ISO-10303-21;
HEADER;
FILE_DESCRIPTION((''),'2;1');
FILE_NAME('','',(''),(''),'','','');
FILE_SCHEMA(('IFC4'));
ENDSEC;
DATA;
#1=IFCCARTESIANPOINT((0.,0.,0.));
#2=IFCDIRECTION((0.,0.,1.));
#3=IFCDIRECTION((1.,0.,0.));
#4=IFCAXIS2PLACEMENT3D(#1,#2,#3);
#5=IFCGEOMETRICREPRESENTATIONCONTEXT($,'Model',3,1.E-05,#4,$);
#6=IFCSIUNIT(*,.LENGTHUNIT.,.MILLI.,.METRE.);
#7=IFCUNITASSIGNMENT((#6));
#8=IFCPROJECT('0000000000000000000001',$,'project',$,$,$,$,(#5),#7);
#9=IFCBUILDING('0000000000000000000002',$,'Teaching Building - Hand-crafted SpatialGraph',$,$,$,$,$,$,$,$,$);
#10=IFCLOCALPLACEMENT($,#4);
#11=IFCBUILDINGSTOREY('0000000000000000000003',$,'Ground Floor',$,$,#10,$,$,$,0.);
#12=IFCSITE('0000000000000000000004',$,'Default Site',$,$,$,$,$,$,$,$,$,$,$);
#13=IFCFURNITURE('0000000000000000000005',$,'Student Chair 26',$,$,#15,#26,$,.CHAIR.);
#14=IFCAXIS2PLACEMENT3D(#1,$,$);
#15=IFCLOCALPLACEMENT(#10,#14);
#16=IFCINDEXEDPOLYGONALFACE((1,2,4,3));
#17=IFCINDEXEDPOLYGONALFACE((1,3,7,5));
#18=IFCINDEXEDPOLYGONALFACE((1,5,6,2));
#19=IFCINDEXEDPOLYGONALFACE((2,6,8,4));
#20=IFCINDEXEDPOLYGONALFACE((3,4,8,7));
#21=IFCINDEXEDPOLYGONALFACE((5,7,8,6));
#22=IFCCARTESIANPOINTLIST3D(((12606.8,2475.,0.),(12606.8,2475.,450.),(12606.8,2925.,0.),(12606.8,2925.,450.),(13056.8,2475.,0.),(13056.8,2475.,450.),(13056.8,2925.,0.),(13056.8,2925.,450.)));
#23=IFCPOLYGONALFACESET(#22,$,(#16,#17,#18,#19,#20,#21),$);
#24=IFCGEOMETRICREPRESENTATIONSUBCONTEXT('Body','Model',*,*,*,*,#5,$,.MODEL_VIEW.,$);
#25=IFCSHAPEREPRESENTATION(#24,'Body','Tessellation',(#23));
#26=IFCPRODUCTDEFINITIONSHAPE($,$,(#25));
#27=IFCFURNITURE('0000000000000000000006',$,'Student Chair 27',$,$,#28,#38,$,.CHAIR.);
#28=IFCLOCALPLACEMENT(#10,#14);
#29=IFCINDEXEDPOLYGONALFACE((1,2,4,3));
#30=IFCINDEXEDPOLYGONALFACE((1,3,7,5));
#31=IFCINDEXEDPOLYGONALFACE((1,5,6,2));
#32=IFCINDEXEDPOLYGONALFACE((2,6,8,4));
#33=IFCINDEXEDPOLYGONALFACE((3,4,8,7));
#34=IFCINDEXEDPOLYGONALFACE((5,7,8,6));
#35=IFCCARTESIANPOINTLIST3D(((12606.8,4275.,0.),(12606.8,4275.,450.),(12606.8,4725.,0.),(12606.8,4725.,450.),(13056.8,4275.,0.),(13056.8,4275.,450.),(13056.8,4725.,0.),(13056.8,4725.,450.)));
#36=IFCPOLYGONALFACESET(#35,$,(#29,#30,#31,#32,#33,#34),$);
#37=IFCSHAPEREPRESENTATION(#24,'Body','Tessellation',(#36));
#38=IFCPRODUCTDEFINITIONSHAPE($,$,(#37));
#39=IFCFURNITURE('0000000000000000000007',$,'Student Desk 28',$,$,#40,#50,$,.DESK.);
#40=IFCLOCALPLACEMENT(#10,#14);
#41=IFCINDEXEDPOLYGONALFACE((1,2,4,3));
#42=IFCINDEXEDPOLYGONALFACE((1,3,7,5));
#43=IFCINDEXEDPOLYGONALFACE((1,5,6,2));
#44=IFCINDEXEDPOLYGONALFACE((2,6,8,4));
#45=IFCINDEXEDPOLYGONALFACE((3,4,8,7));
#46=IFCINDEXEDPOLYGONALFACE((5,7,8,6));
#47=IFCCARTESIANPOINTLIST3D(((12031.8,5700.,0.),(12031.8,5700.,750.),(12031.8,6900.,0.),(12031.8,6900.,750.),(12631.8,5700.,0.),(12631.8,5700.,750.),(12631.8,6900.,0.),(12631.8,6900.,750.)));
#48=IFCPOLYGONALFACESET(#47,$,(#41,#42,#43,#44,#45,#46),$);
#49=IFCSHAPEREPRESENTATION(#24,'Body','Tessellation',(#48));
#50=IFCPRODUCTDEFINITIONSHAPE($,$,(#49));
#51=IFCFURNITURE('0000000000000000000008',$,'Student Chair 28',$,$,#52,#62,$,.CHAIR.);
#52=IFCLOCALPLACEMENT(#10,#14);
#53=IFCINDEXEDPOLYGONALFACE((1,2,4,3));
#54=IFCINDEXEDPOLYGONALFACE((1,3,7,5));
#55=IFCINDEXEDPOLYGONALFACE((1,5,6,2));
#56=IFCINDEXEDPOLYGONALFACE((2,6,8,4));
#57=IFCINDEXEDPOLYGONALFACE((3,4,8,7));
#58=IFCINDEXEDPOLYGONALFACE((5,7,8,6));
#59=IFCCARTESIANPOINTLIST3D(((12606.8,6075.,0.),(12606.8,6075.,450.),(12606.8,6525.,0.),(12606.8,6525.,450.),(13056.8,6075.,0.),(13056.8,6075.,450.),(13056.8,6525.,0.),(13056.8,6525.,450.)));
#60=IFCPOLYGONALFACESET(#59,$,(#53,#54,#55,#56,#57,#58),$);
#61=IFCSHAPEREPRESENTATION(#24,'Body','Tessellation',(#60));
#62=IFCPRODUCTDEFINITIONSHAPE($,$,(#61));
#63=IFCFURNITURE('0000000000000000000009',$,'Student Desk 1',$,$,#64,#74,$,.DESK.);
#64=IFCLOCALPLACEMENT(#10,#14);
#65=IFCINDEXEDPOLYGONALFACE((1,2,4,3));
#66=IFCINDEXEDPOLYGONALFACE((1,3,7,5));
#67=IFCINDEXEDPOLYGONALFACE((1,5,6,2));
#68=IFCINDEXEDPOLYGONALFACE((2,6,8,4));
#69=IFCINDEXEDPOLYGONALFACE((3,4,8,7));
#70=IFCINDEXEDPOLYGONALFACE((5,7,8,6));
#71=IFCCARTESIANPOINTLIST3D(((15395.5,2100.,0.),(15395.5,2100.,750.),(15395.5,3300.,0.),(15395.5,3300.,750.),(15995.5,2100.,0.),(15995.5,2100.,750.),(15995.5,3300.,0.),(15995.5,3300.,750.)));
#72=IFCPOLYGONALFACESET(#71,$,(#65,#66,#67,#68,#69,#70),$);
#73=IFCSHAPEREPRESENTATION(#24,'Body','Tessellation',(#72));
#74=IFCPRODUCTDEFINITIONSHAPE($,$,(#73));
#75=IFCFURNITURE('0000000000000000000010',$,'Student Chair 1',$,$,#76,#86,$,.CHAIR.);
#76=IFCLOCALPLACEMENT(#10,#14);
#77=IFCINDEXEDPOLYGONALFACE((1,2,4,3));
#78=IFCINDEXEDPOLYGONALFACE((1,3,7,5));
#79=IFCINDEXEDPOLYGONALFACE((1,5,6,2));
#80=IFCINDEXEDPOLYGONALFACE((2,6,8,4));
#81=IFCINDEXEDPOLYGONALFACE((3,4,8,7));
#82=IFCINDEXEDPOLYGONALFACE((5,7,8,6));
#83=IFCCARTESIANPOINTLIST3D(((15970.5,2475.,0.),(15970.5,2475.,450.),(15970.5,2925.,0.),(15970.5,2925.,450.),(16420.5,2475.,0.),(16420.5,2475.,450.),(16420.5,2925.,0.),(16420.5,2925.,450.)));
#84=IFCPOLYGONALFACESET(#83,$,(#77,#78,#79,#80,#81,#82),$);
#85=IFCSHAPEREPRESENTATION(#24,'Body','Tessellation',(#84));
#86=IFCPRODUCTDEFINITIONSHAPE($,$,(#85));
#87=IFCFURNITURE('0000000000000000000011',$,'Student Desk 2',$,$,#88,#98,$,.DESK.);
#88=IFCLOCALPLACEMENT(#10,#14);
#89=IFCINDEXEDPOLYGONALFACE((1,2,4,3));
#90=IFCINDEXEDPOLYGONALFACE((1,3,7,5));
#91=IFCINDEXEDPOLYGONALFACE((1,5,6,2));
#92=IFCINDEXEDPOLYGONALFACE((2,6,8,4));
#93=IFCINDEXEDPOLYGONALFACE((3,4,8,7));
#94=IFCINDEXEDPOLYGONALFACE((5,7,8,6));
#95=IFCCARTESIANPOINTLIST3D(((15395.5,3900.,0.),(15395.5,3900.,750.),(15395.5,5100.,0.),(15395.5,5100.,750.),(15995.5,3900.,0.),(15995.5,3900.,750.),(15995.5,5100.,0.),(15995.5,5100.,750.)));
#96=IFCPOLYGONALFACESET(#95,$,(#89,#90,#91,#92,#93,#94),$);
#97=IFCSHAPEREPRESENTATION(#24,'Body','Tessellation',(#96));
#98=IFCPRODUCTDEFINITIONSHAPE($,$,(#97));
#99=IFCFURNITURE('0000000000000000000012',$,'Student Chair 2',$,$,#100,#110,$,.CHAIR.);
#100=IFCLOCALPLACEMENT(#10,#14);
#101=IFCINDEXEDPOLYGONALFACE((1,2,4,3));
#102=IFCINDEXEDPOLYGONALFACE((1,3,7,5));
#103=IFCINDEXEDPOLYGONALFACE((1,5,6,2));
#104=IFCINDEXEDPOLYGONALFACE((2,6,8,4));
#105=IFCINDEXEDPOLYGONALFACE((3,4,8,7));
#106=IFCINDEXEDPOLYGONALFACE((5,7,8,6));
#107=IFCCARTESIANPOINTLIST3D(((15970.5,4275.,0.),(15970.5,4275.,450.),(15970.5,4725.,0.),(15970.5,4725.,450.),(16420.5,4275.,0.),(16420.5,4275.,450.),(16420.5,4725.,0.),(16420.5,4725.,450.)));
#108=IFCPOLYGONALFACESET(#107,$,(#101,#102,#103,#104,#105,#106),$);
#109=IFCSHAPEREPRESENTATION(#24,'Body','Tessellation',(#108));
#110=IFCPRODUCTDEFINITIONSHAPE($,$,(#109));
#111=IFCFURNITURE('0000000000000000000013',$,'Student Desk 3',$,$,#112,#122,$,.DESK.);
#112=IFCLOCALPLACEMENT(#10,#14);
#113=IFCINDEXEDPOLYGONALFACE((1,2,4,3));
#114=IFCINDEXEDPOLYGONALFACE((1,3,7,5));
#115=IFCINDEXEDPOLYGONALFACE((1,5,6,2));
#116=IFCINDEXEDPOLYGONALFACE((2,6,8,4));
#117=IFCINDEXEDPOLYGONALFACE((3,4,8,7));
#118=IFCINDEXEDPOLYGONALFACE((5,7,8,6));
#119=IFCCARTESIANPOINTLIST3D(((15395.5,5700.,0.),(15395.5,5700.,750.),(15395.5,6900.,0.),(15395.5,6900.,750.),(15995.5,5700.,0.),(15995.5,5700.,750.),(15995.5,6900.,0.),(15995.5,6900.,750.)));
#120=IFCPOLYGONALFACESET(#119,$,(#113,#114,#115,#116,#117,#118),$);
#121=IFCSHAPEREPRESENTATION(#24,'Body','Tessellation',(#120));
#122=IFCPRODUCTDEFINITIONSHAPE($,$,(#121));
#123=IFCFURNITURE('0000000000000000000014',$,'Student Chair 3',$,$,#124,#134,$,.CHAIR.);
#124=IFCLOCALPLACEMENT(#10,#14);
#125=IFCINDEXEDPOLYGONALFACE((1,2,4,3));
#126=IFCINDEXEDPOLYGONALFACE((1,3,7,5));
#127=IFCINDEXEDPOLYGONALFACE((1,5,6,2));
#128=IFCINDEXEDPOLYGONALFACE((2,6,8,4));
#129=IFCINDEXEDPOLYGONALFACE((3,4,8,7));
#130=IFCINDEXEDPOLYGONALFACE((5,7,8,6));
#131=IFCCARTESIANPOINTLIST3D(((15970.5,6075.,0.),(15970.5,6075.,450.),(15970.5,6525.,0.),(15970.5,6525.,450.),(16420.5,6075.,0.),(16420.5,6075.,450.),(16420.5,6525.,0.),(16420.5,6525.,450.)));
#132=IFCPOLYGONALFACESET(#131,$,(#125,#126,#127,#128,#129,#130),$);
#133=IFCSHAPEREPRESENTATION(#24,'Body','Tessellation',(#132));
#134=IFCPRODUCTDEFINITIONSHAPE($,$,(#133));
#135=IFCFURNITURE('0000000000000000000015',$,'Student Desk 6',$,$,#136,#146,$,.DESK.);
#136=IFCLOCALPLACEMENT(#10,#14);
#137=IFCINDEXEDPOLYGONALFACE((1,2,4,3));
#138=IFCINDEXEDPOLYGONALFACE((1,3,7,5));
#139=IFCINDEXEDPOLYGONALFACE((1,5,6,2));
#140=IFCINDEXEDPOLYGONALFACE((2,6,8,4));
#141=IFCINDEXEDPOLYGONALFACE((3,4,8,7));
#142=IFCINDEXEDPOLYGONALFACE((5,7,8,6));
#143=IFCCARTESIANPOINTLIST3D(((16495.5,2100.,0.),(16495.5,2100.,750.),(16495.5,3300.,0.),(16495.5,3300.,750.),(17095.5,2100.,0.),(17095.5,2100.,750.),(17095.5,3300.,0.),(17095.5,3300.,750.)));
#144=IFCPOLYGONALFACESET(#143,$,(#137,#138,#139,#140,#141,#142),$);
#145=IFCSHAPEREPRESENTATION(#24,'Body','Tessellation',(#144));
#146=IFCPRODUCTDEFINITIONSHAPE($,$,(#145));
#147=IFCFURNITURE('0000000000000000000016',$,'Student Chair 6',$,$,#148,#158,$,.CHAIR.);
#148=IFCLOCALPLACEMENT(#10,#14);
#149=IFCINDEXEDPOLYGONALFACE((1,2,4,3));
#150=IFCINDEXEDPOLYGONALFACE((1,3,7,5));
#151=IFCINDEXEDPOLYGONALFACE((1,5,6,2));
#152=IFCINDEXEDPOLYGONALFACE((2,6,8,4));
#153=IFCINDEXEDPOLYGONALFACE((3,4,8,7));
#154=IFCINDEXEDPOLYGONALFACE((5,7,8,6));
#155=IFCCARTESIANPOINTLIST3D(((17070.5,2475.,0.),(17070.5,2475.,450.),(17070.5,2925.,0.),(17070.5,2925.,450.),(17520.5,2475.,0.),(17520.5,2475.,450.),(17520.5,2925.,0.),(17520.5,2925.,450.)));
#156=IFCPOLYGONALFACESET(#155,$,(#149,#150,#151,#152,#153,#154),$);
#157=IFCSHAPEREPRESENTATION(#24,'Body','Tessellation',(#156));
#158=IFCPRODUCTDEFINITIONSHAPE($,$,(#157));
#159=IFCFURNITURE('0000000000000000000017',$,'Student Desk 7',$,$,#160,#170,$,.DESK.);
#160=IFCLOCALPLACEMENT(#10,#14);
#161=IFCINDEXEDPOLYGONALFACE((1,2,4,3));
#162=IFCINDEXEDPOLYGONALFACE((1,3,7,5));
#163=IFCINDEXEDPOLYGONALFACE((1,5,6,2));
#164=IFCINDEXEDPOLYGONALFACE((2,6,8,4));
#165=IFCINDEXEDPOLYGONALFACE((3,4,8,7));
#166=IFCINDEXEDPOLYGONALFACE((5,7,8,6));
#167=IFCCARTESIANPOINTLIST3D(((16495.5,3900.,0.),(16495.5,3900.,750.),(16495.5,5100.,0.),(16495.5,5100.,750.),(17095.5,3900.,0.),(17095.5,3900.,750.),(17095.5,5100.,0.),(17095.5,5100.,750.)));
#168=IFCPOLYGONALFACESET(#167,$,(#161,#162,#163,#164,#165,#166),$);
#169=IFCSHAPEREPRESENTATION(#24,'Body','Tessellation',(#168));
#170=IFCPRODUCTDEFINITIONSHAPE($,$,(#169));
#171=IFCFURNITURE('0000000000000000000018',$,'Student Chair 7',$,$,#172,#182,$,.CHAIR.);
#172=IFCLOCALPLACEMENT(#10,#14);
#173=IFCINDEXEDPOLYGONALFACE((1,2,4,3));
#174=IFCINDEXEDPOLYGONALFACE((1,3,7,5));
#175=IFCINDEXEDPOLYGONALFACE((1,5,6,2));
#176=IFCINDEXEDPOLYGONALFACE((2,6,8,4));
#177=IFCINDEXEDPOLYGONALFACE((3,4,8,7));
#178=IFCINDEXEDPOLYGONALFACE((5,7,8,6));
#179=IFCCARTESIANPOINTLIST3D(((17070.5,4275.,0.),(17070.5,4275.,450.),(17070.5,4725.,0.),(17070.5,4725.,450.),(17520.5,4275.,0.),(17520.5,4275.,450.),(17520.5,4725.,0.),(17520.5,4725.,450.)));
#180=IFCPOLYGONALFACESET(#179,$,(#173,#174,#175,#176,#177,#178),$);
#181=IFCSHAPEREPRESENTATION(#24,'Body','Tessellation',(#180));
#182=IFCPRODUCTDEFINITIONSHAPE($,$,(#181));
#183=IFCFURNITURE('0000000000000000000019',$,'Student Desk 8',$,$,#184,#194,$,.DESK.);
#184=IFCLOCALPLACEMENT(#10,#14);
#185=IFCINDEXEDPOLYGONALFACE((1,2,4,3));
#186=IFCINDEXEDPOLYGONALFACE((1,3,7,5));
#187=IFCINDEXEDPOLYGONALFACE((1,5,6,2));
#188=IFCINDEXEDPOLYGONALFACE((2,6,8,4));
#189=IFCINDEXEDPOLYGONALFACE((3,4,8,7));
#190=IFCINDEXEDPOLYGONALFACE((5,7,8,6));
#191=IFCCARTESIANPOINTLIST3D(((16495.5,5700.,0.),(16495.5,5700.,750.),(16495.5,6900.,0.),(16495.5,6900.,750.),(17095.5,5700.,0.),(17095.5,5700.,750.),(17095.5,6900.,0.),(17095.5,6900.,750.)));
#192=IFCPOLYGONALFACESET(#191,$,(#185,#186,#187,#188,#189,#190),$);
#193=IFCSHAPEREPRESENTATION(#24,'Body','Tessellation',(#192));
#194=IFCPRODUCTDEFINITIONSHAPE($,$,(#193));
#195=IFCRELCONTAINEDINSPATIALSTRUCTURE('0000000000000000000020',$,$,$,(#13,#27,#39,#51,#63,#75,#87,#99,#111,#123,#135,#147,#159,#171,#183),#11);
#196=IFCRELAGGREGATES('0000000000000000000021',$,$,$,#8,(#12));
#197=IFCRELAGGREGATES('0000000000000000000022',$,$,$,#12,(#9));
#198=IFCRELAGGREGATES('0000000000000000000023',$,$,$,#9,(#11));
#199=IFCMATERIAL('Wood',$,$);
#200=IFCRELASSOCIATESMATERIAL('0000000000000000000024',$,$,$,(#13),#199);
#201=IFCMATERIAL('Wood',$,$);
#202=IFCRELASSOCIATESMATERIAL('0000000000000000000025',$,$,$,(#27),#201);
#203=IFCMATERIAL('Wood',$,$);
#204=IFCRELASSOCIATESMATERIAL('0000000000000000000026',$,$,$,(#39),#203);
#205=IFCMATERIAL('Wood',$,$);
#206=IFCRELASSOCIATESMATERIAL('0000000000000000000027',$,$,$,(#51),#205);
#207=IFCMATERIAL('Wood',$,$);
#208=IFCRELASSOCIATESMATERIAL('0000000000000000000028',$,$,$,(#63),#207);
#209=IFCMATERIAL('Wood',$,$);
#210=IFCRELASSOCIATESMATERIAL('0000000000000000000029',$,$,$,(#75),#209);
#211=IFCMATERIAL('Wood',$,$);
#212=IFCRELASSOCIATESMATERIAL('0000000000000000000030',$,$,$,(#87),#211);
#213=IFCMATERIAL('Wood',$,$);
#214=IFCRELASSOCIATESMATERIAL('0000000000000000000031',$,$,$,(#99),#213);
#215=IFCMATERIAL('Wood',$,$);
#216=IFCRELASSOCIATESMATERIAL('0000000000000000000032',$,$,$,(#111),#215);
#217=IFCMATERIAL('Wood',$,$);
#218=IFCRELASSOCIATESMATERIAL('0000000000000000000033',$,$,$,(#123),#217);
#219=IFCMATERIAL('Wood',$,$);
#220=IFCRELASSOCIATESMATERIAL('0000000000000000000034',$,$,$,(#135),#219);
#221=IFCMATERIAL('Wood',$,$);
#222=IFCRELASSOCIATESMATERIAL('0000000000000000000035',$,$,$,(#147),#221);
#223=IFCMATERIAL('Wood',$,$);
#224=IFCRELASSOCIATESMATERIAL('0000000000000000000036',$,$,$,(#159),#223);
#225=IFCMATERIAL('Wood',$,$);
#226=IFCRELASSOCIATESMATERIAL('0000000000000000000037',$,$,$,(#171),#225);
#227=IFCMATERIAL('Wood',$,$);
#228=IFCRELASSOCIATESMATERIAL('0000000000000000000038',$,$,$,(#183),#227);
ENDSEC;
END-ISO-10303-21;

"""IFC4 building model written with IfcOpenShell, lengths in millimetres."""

from ifc_helpers import new_model, si_unit, frame, origin_with_axes, origin_2d, place, context, subcontext, project, spatial, rectangle, extrude, material, element, save


model = new_model("IFC4")

# Units and contexts
model_context = context("Model", 3, precision=1e-05, world=origin_with_axes())
body_context = subcontext(model_context, "Body", "Model", "MODEL_VIEW")
ifc_project = project(units=[si_unit("LENGTHUNIT", "METRE", prefix="MILLI")], contexts=[model_context])

# Site, building, storey
site = spatial("IfcSite", under=ifc_project, Name="Default Site")
building = spatial("IfcBuilding", under=site, Name="Teaching Building - Hand-crafted SpatialGraph")
storey_placement = place(None, origin_with_axes())
storey = spatial("IfcBuildingStorey", under=building, at=storey_placement, Name="Ground Floor", Elevation=0.0)

# Furniture
ifc_material_1 = material(Name="Wood")
furniture_1_placement = place(storey_placement, frame((12831.8, 2700.0, 0.0), z_axis=(0.0, 0.0, 1.0), x_axis=(1.0, 0.0, 0.0)))
element("IfcFurniture", 1, at=furniture_1_placement, inside=storey, material=ifc_material_1, Name="Student Chair 26", PredefinedType="CHAIR", context=body_context, shape_type="SweptSolid", body=[
    extrude(rectangle(XDim=450.0, YDim=450.0, at=origin_2d()), origin_with_axes(), (0.0, 0.0, 1.0), 450.0),
])
ifc_material_2 = material(Name="Wood")
furniture_2_placement = place(storey_placement, frame((12831.8, 4500.0, 0.0), z_axis=(0.0, 0.0, 1.0), x_axis=(1.0, 0.0, 0.0)))
element("IfcFurniture", 2, at=furniture_2_placement, inside=storey, material=ifc_material_2, Name="Student Chair 27", PredefinedType="CHAIR", context=body_context, shape_type="SweptSolid", body=[
    extrude(rectangle(XDim=450.0, YDim=450.0, at=origin_2d()), origin_with_axes(), (0.0, 0.0, 1.0), 450.0),
])
ifc_material_3 = material(Name="Wood")
furniture_3_placement = place(storey_placement, frame((12331.8, 6300.0, 0.0), z_axis=(0.0, 0.0, 1.0), x_axis=(0.0, 1.0, 0.0)))
element("IfcFurniture", 3, at=furniture_3_placement, inside=storey, material=ifc_material_3, Name="Student Desk 28", PredefinedType="DESK", context=body_context, shape_type="SweptSolid", body=[
    extrude(rectangle(XDim=1200.0, YDim=600.0, at=origin_2d()), origin_with_axes(), (0.0, 0.0, 1.0), 750.0),
])
ifc_material_4 = material(Name="Wood")
furniture_4_placement = place(storey_placement, frame((12831.8, 6300.0, 0.0), z_axis=(0.0, 0.0, 1.0), x_axis=(1.0, 0.0, 0.0)))
element("IfcFurniture", 4, at=furniture_4_placement, inside=storey, material=ifc_material_4, Name="Student Chair 28", PredefinedType="CHAIR", context=body_context, shape_type="SweptSolid", body=[
    extrude(rectangle(XDim=450.0, YDim=450.0, at=origin_2d()), origin_with_axes(), (0.0, 0.0, 1.0), 450.0),
])
ifc_material_5 = material(Name="Wood")
furniture_5_placement = place(storey_placement, frame((15695.5, 2700.0, 0.0), z_axis=(0.0, 0.0, 1.0), x_axis=(0.0, 1.0, 0.0)))
element("IfcFurniture", 5, at=furniture_5_placement, inside=storey, material=ifc_material_5, Name="Student Desk 1", PredefinedType="DESK", context=body_context, shape_type="SweptSolid", body=[
    extrude(rectangle(XDim=1200.0, YDim=600.0, at=origin_2d()), origin_with_axes(), (0.0, 0.0, 1.0), 750.0),
])
ifc_material_6 = material(Name="Wood")
furniture_6_placement = place(storey_placement, frame((16195.5, 2700.0, 0.0), z_axis=(0.0, 0.0, 1.0), x_axis=(1.0, 0.0, 0.0)))
element("IfcFurniture", 6, at=furniture_6_placement, inside=storey, material=ifc_material_6, Name="Student Chair 1", PredefinedType="CHAIR", context=body_context, shape_type="SweptSolid", body=[
    extrude(rectangle(XDim=450.0, YDim=450.0, at=origin_2d()), origin_with_axes(), (0.0, 0.0, 1.0), 450.0),
])
ifc_material_7 = material(Name="Wood")
furniture_7_placement = place(storey_placement, frame((15695.5, 4500.0, 0.0), z_axis=(0.0, 0.0, 1.0), x_axis=(0.0, 1.0, 0.0)))
element("IfcFurniture", 7, at=furniture_7_placement, inside=storey, material=ifc_material_7, Name="Student Desk 2", PredefinedType="DESK", context=body_context, shape_type="SweptSolid", body=[
    extrude(rectangle(XDim=1200.0, YDim=600.0, at=origin_2d()), origin_with_axes(), (0.0, 0.0, 1.0), 750.0),
])
ifc_material_8 = material(Name="Wood")
furniture_8_placement = place(storey_placement, frame((16195.5, 4500.0, 0.0), z_axis=(0.0, 0.0, 1.0), x_axis=(1.0, 0.0, 0.0)))
element("IfcFurniture", 8, at=furniture_8_placement, inside=storey, material=ifc_material_8, Name="Student Chair 2", PredefinedType="CHAIR", context=body_context, shape_type="SweptSolid", body=[
    extrude(rectangle(XDim=450.0, YDim=450.0, at=origin_2d()), origin_with_axes(), (0.0, 0.0, 1.0), 450.0),
])
ifc_material_9 = material(Name="Wood")
furniture_9_placement = place(storey_placement, frame((15695.5, 6300.0, 0.0), z_axis=(0.0, 0.0, 1.0), x_axis=(0.0, 1.0, 0.0)))
element("IfcFurniture", 9, at=furniture_9_placement, inside=storey, material=ifc_material_9, Name="Student Desk 3", PredefinedType="DESK", context=body_context, shape_type="SweptSolid", body=[
    extrude(rectangle(XDim=1200.0, YDim=600.0, at=origin_2d()), origin_with_axes(), (0.0, 0.0, 1.0), 750.0),
])
ifc_material_10 = material(Name="Wood")
furniture_10_placement = place(storey_placement, frame((16195.5, 6300.0, 0.0), z_axis=(0.0, 0.0, 1.0), x_axis=(1.0, 0.0, 0.0)))
element("IfcFurniture", 10, at=furniture_10_placement, inside=storey, material=ifc_material_10, Name="Student Chair 3", PredefinedType="CHAIR", context=body_context, shape_type="SweptSolid", body=[
    extrude(rectangle(XDim=450.0, YDim=450.0, at=origin_2d()), origin_with_axes(), (0.0, 0.0, 1.0), 450.0),
])
ifc_material_11 = material(Name="Wood")
furniture_11_placement = place(storey_placement, frame((16795.5, 2700.0, 0.0), z_axis=(0.0, 0.0, 1.0), x_axis=(0.0, 1.0, 0.0)))
element("IfcFurniture", 11, at=furniture_11_placement, inside=storey, material=ifc_material_11, Name="Student Desk 6", PredefinedType="DESK", context=body_context, shape_type="SweptSolid", body=[
    extrude(rectangle(XDim=1200.0, YDim=600.0, at=origin_2d()), origin_with_axes(), (0.0, 0.0, 1.0), 750.0),
])
ifc_material_12 = material(Name="Wood")
furniture_12_placement = place(storey_placement, frame((17295.5, 2700.0, 0.0), z_axis=(0.0, 0.0, 1.0), x_axis=(1.0, 0.0, 0.0)))
element("IfcFurniture", 12, at=furniture_12_placement, inside=storey, material=ifc_material_12, Name="Student Chair 6", PredefinedType="CHAIR", context=body_context, shape_type="SweptSolid", body=[
    extrude(rectangle(XDim=450.0, YDim=450.0, at=origin_2d()), origin_with_axes(), (0.0, 0.0, 1.0), 450.0),
])
ifc_material_13 = material(Name="Wood")
furniture_13_placement = place(storey_placement, frame((16795.5, 4500.0, 0.0), z_axis=(0.0, 0.0, 1.0), x_axis=(0.0, 1.0, 0.0)))
element("IfcFurniture", 13, at=furniture_13_placement, inside=storey, material=ifc_material_13, Name="Student Desk 7", PredefinedType="DESK", context=body_context, shape_type="SweptSolid", body=[
    extrude(rectangle(XDim=1200.0, YDim=600.0, at=origin_2d()), origin_with_axes(), (0.0, 0.0, 1.0), 750.0),
])
ifc_material_14 = material(Name="Wood")
furniture_14_placement = place(storey_placement, frame((17295.5, 4500.0, 0.0), z_axis=(0.0, 0.0, 1.0), x_axis=(1.0, 0.0, 0.0)))
element("IfcFurniture", 14, at=furniture_14_placement, inside=storey, material=ifc_material_14, Name="Student Chair 7", PredefinedType="CHAIR", context=body_context, shape_type="SweptSolid", body=[
    extrude(rectangle(XDim=450.0, YDim=450.0, at=origin_2d()), origin_with_axes(), (0.0, 0.0, 1.0), 450.0),
])
ifc_material_15 = material(Name="Wood")
furniture_15_placement = place(storey_placement, frame((16795.5, 6300.0, 0.0), z_axis=(0.0, 0.0, 1.0), x_axis=(0.0, 1.0, 0.0)))
element("IfcFurniture", 15, at=furniture_15_placement, inside=storey, material=ifc_material_15, Name="Student Desk 8", PredefinedType="DESK", context=body_context, shape_type="SweptSolid", body=[
    extrude(rectangle(XDim=1200.0, YDim=600.0, at=origin_2d()), origin_with_axes(), (0.0, 0.0, 1.0), 750.0),
])

save(model, "model.ifc")
